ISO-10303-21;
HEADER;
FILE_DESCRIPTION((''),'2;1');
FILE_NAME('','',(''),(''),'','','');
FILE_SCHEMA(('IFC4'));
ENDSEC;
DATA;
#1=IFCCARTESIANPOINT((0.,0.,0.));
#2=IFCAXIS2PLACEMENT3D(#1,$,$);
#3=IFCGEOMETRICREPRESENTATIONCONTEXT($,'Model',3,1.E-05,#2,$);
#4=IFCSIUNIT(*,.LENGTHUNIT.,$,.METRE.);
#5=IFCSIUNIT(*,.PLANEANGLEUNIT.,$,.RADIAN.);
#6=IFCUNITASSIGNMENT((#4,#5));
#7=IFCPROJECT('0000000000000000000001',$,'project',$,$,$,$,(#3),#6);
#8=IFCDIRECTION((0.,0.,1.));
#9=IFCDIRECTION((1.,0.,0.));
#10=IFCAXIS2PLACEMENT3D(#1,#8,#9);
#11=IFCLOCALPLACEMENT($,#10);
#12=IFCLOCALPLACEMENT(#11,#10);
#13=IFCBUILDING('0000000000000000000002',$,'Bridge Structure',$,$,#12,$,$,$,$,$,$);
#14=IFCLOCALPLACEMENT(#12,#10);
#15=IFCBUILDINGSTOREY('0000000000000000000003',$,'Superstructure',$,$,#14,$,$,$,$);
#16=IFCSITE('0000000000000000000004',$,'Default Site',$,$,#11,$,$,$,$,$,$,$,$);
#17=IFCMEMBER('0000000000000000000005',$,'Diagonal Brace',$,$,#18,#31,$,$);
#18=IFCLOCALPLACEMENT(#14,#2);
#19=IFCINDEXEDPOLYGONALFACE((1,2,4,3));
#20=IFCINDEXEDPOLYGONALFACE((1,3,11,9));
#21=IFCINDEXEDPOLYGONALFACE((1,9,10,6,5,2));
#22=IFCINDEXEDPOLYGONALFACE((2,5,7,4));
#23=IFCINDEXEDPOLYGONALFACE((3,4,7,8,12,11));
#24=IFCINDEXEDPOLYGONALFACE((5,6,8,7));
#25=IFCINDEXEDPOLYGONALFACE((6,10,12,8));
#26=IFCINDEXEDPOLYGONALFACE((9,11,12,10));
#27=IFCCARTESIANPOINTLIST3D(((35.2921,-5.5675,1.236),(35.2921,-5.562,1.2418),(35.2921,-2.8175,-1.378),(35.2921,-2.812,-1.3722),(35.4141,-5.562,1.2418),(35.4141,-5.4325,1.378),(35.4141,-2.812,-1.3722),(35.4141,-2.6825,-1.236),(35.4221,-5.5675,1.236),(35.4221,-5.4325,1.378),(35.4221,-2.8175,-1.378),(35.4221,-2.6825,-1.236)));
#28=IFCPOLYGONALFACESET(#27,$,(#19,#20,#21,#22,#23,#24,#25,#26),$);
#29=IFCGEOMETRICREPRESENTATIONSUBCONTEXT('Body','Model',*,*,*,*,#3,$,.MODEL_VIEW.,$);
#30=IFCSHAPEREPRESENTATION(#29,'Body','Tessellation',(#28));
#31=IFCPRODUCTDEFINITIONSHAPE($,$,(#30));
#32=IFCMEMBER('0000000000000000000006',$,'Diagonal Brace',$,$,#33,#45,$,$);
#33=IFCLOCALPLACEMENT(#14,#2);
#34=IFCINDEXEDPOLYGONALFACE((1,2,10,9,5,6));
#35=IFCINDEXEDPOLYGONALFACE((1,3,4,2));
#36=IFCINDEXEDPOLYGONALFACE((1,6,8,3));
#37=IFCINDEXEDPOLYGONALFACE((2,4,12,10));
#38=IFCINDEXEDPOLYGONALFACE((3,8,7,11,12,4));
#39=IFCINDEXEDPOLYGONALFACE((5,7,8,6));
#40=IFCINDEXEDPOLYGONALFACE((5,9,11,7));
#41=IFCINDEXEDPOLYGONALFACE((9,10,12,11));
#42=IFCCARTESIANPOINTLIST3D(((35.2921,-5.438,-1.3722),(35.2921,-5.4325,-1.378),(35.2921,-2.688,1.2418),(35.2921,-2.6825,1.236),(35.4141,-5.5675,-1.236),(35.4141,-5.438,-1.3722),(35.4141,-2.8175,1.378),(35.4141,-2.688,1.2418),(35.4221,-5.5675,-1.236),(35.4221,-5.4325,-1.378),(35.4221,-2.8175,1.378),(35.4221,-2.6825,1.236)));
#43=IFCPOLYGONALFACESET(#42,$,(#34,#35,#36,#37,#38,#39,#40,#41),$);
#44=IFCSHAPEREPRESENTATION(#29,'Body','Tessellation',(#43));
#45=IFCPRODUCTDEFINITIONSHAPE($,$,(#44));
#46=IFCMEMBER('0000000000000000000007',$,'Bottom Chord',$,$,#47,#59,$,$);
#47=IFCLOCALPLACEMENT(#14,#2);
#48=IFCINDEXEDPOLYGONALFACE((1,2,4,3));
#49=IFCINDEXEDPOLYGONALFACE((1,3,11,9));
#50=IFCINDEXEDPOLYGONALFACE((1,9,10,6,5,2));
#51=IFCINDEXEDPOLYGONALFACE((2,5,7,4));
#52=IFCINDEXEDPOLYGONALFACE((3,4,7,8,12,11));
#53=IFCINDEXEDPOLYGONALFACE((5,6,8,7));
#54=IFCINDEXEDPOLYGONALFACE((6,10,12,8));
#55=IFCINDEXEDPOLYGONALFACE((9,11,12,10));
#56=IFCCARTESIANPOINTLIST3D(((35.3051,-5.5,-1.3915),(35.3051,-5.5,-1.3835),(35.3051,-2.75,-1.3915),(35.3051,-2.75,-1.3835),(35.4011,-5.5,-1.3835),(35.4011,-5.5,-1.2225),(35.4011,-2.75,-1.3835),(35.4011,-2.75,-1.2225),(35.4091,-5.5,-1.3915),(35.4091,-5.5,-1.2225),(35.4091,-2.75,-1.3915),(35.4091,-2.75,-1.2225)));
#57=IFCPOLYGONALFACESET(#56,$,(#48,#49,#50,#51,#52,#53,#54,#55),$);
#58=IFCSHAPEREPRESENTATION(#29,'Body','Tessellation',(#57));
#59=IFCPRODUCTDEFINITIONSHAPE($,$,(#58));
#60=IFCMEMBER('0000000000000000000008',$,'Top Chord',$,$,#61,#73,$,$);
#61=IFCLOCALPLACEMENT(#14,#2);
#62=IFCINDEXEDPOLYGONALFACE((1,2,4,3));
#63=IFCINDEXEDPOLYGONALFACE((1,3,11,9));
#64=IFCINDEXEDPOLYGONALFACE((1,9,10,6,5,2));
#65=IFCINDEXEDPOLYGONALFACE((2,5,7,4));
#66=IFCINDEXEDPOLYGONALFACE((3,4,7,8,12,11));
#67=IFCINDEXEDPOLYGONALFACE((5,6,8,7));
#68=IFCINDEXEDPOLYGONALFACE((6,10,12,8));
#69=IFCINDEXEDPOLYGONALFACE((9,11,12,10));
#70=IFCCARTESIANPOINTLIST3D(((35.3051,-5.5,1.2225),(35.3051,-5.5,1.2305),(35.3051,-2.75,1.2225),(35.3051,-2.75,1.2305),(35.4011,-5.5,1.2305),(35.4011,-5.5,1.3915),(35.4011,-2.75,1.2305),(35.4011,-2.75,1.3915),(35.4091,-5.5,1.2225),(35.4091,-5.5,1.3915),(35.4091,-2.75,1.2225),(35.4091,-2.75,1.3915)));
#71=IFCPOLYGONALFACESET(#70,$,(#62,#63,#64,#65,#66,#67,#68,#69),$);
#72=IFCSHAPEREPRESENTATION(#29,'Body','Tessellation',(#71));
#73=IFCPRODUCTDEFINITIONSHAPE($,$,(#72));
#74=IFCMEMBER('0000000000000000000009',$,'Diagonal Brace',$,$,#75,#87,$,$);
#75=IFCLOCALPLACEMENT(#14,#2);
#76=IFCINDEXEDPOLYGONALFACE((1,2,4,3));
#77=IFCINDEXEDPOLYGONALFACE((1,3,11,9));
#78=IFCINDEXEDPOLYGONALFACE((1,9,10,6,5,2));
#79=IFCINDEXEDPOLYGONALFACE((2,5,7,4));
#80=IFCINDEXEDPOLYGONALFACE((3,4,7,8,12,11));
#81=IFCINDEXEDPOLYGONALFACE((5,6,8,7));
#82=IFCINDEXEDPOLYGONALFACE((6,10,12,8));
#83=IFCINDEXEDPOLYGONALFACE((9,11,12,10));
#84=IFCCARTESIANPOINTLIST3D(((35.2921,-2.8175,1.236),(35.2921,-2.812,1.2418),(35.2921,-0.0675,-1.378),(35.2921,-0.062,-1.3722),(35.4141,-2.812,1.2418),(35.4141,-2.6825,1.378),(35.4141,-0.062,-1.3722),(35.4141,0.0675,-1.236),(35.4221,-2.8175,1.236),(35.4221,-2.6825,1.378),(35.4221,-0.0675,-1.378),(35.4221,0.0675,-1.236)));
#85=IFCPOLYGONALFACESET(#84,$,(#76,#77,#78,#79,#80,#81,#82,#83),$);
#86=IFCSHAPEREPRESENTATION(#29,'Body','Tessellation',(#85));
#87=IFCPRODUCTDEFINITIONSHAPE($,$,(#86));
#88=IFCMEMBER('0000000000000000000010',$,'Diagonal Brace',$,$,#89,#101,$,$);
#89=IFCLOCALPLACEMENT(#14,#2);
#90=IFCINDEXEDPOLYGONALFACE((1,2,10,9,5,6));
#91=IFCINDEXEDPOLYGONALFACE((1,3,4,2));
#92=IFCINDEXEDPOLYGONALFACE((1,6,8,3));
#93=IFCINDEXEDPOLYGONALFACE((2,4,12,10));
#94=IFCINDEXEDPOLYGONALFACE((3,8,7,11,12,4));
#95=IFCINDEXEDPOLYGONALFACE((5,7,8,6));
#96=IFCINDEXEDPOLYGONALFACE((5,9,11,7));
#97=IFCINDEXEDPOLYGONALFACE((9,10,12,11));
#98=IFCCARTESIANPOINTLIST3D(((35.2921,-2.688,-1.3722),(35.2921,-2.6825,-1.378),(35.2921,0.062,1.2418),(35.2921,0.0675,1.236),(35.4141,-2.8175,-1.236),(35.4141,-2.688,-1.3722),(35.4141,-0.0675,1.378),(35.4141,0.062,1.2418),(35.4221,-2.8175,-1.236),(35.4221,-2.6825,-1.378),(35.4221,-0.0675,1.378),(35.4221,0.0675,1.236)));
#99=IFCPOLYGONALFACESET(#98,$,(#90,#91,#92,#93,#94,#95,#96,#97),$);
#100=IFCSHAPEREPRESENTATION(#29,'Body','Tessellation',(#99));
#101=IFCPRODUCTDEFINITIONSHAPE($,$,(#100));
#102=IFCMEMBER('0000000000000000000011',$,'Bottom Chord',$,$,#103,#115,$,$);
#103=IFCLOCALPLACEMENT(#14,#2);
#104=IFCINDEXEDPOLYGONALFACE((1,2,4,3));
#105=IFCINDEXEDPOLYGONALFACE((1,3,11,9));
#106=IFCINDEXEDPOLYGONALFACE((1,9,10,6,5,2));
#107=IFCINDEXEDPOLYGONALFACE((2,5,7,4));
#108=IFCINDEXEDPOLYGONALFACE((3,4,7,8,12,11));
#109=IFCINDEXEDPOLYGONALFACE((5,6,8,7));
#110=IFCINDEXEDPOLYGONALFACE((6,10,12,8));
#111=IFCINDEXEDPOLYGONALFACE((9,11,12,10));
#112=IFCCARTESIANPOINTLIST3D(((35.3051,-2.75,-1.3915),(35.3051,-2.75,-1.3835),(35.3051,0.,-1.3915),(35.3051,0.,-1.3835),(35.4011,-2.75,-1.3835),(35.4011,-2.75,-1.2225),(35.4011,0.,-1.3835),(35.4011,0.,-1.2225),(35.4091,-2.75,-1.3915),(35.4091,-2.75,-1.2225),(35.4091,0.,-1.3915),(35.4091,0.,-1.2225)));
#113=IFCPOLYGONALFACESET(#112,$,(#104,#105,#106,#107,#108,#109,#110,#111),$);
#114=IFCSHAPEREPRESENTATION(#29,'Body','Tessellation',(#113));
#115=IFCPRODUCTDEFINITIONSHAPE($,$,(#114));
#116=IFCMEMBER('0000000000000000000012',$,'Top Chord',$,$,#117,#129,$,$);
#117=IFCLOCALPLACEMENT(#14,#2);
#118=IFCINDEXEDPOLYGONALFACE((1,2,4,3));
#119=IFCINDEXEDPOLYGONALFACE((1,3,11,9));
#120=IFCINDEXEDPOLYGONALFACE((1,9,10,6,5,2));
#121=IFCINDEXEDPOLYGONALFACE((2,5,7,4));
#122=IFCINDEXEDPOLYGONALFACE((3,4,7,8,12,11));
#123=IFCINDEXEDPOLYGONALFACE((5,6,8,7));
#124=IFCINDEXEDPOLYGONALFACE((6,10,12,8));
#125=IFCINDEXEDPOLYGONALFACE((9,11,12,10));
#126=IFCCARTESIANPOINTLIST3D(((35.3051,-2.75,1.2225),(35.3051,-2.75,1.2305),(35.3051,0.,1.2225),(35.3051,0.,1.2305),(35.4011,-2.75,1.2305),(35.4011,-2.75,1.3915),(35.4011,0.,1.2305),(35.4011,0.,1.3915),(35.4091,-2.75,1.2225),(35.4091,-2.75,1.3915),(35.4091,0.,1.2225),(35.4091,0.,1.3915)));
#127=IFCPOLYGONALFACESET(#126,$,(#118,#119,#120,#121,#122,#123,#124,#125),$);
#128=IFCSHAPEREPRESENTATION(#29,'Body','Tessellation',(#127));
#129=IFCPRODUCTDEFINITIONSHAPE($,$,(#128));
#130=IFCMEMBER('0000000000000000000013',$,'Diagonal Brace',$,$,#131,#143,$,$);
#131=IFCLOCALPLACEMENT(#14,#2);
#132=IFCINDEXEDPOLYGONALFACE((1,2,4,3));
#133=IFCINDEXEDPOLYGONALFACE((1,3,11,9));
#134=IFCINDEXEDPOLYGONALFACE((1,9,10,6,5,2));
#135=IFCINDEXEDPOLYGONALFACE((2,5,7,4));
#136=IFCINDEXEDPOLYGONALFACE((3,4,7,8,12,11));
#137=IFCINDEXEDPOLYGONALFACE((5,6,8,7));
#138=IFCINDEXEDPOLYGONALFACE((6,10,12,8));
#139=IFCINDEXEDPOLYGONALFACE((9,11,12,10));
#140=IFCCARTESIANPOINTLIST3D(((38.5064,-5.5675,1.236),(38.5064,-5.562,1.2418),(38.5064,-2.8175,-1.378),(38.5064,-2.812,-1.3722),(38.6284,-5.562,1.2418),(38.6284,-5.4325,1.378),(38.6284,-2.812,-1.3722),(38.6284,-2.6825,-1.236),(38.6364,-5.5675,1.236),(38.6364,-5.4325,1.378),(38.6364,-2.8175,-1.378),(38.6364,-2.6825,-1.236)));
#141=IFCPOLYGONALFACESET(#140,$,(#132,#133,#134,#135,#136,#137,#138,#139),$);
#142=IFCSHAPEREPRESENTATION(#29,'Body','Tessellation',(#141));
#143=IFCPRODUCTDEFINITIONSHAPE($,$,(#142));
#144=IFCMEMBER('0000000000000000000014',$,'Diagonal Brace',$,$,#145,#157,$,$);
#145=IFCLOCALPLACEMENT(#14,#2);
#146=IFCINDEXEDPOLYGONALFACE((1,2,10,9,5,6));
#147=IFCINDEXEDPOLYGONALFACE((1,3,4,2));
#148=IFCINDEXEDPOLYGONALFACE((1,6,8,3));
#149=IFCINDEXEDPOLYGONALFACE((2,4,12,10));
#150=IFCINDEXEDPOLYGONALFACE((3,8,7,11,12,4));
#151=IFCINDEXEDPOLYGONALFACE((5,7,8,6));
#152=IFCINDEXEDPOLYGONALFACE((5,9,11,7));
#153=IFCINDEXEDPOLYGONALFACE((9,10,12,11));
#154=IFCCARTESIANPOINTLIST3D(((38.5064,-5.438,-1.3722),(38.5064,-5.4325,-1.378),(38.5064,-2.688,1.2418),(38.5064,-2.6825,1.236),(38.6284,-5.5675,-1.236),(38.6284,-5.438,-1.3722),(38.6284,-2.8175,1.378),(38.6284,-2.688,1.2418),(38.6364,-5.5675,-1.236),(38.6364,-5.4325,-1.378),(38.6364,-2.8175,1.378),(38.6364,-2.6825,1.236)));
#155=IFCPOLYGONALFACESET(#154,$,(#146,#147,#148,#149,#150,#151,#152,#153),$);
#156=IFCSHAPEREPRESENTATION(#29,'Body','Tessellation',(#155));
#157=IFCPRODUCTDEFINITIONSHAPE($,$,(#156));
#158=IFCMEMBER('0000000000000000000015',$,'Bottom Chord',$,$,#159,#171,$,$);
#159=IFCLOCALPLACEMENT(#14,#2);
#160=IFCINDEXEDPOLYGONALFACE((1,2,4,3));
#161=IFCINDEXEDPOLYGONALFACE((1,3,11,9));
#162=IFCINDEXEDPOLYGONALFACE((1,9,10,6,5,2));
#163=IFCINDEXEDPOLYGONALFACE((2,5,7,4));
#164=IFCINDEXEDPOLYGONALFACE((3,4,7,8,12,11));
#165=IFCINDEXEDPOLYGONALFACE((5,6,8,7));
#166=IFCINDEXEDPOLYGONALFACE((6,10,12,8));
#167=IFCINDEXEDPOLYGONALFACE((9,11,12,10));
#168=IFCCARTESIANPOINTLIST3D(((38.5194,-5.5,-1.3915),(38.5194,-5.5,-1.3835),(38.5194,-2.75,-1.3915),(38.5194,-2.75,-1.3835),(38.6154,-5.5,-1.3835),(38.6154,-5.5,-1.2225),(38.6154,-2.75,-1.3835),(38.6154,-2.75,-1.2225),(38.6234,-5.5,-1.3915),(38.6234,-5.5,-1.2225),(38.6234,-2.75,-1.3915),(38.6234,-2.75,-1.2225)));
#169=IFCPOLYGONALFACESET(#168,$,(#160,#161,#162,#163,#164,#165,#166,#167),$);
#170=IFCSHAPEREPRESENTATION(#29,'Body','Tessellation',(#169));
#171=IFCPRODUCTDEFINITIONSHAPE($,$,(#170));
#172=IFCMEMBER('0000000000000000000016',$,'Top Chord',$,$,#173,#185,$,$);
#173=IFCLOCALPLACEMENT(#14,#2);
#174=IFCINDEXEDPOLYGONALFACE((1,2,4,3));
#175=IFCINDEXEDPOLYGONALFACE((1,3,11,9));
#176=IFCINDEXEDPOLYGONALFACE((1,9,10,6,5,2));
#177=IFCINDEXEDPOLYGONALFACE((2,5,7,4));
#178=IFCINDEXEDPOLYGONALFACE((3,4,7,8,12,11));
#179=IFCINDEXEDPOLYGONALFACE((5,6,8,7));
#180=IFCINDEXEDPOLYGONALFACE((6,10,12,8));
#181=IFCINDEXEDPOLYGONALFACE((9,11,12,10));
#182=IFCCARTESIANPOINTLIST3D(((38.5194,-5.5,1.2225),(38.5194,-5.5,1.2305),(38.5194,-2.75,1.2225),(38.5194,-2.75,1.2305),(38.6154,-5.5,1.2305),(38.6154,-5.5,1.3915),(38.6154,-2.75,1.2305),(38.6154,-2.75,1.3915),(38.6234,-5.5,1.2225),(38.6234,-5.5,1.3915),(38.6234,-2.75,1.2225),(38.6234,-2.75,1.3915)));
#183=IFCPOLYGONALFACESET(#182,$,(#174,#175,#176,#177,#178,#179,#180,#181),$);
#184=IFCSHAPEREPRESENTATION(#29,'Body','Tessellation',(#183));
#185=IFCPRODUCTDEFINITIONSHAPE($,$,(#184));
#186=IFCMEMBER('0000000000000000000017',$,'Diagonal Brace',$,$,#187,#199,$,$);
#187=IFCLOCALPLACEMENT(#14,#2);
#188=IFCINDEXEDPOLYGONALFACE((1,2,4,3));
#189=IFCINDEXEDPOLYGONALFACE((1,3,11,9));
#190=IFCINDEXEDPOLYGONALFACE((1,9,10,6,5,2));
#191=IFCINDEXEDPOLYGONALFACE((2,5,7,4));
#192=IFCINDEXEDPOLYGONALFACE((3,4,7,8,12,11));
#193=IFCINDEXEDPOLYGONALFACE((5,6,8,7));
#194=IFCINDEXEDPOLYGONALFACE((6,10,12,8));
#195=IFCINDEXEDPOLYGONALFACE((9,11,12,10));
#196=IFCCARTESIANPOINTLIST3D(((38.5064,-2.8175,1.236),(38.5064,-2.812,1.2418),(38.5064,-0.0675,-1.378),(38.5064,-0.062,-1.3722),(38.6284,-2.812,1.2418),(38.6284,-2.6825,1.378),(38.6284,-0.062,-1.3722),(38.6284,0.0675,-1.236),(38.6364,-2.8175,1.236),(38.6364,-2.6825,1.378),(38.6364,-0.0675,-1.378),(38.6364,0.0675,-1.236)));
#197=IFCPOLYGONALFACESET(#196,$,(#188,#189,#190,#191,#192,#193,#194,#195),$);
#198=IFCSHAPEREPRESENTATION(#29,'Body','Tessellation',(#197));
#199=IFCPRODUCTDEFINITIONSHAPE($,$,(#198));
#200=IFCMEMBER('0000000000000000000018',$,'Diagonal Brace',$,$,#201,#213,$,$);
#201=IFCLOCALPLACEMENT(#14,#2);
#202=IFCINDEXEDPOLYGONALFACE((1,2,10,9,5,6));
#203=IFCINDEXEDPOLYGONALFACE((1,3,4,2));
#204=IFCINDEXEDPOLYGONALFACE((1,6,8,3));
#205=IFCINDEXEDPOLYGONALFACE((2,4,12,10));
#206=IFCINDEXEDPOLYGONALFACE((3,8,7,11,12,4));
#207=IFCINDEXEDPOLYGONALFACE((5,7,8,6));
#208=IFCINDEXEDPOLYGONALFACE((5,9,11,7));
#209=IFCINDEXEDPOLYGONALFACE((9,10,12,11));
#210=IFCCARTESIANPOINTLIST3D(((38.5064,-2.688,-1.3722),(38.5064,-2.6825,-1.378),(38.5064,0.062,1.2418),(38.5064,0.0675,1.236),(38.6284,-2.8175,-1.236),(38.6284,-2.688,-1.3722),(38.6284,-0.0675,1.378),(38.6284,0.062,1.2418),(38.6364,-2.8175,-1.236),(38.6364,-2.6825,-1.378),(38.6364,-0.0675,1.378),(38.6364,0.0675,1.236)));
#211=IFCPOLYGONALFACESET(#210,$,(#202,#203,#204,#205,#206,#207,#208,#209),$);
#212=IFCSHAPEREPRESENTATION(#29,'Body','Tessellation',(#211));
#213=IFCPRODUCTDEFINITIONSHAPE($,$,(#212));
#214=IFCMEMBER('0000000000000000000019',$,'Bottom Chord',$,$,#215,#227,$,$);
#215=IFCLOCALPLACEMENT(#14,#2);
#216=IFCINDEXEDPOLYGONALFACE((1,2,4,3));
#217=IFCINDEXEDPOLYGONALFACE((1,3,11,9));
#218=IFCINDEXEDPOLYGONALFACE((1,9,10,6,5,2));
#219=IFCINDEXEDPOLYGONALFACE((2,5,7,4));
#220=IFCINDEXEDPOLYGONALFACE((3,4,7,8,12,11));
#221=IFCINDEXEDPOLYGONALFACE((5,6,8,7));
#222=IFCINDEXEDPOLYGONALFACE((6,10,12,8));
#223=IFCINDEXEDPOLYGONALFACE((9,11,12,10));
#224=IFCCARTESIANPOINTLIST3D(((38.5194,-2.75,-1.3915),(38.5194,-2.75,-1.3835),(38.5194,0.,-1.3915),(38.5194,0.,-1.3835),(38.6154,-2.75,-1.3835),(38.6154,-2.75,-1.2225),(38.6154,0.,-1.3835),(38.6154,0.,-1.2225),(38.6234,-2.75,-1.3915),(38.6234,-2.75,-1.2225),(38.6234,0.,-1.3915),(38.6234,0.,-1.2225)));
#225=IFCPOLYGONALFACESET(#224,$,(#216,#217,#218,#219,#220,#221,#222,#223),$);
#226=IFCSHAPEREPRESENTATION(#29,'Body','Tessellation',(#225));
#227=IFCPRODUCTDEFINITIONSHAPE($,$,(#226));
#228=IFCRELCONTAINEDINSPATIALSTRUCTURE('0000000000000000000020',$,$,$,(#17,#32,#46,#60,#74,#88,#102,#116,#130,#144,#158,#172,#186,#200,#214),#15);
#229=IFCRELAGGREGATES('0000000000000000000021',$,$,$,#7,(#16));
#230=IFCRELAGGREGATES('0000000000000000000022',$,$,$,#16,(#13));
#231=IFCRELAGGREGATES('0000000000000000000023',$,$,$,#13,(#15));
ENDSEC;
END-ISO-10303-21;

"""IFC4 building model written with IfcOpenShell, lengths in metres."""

from ifc_helpers import new_model, si_unit, frame, origin, origin_with_axes, origin_2d_with_axis, place, context, subcontext, project, spatial, l_section, extrude, element, save


model = new_model("IFC4")

# Units and contexts
model_context = context("Model", 3, precision=1e-05, world=origin())
body_context = subcontext(model_context, "Body", "Model", "MODEL_VIEW")
ifc_project = project(units=[si_unit("LENGTHUNIT", "METRE"), si_unit("PLANEANGLEUNIT", "RADIAN")], contexts=[model_context])

# Site, building, storey
site_placement = place(None, origin_with_axes())
site = spatial("IfcSite", under=ifc_project, at=site_placement, Name="Default Site")
building_placement = place(site_placement, origin_with_axes())
building = spatial("IfcBuilding", under=site, at=building_placement, Name="Bridge Structure")
storey_placement = place(building_placement, origin_with_axes())
storey = spatial("IfcBuildingStorey", under=building, at=storey_placement, Name="Superstructure")

# Members
for number, where, z_axis, x_axis, name in (
    (1, (35.3571, -5.5, 1.307), (0.0, 0.724802, -0.688957), (-1.0, 0.0, 0.0), "Diagonal Brace"),
    (2, (35.3571, -5.5, -1.307), (0.0, 0.724802, 0.688957), (-1.0, 0.0, 0.0), "Diagonal Brace"),
):
    element("IfcMember", number, at=place(storey_placement, frame(where, z_axis=z_axis, x_axis=x_axis)), inside=storey, Name=name, context=body_context, shape_type="SweptSolid", body=[
        extrude(l_section(Depth=0.196, Width=0.13, Thickness=0.008, at=origin_2d_with_axis()), origin_with_axes(), (0.0, 0.0, 1.0), 3.7941),
    ])
for number, where, z_axis, x_axis, name in (
    (3, (35.3571, -5.5, -1.307), (0.0, 1.0, 0.0), (-1.0, 0.0, 0.0), "Bottom Chord"),
    (4, (35.3571, -5.5, 1.307), (0.0, 1.0, 0.0), (-1.0, 0.0, 0.0), "Top Chord"),
):
    element("IfcMember", number, at=place(storey_placement, frame(where, z_axis=z_axis, x_axis=x_axis)), inside=storey, Name=name, context=body_context, shape_type="SweptSolid", body=[
        extrude(l_section(Depth=0.169, Width=0.104, Thickness=0.008, at=origin_2d_with_axis()), origin_with_axes(), (0.0, 0.0, 1.0), 2.75),
    ])
for number, where, z_axis, x_axis, name in (
    (5, (35.3571, -2.75, 1.307), (0.0, 0.724802, -0.688957), (-1.0, 0.0, 0.0), "Diagonal Brace"),
    (6, (35.3571, -2.75, -1.307), (0.0, 0.724802, 0.688957), (-1.0, 0.0, 0.0), "Diagonal Brace"),
):
    element("IfcMember", number, at=place(storey_placement, frame(where, z_axis=z_axis, x_axis=x_axis)), inside=storey, Name=name, context=body_context, shape_type="SweptSolid", body=[
        extrude(l_section(Depth=0.196, Width=0.13, Thickness=0.008, at=origin_2d_with_axis()), origin_with_axes(), (0.0, 0.0, 1.0), 3.7941),
    ])
for number, where, z_axis, x_axis, name in (
    (7, (35.3571, -2.75, -1.307), (0.0, 1.0, 0.0), (-1.0, 0.0, 0.0), "Bottom Chord"),
    (8, (35.3571, -2.75, 1.307), (0.0, 1.0, 0.0), (-1.0, 0.0, 0.0), "Top Chord"),
):
    element("IfcMember", number, at=place(storey_placement, frame(where, z_axis=z_axis, x_axis=x_axis)), inside=storey, Name=name, context=body_context, shape_type="SweptSolid", body=[
        extrude(l_section(Depth=0.169, Width=0.104, Thickness=0.008, at=origin_2d_with_axis()), origin_with_axes(), (0.0, 0.0, 1.0), 2.75),
    ])
for number, where, z_axis, x_axis, name in (
    (9, (38.5714, -5.5, 1.307), (0.0, 0.724802, -0.688957), (-1.0, 0.0, 0.0), "Diagonal Brace"),
    (10, (38.5714, -5.5, -1.307), (0.0, 0.724802, 0.688957), (-1.0, 0.0, 0.0), "Diagonal Brace"),
):
    element("IfcMember", number, at=place(storey_placement, frame(where, z_axis=z_axis, x_axis=x_axis)), inside=storey, Name=name, context=body_context, shape_type="SweptSolid", body=[
        extrude(l_section(Depth=0.196, Width=0.13, Thickness=0.008, at=origin_2d_with_axis()), origin_with_axes(), (0.0, 0.0, 1.0), 3.7941),
    ])
for number, where, z_axis, x_axis, name in (
    (11, (38.5714, -5.5, -1.307), (0.0, 1.0, 0.0), (-1.0, 0.0, 0.0), "Bottom Chord"),
    (12, (38.5714, -5.5, 1.307), (0.0, 1.0, 0.0), (-1.0, 0.0, 0.0), "Top Chord"),
):
    element("IfcMember", number, at=place(storey_placement, frame(where, z_axis=z_axis, x_axis=x_axis)), inside=storey, Name=name, context=body_context, shape_type="SweptSolid", body=[
        extrude(l_section(Depth=0.169, Width=0.104, Thickness=0.008, at=origin_2d_with_axis()), origin_with_axes(), (0.0, 0.0, 1.0), 2.75),
    ])
for number, where, z_axis, x_axis, name in (
    (13, (38.5714, -2.75, 1.307), (0.0, 0.724802, -0.688957), (-1.0, 0.0, 0.0), "Diagonal Brace"),
    (14, (38.5714, -2.75, -1.307), (0.0, 0.724802, 0.688957), (-1.0, 0.0, 0.0), "Diagonal Brace"),
):
    element("IfcMember", number, at=place(storey_placement, frame(where, z_axis=z_axis, x_axis=x_axis)), inside=storey, Name=name, context=body_context, shape_type="SweptSolid", body=[
        extrude(l_section(Depth=0.196, Width=0.13, Thickness=0.008, at=origin_2d_with_axis()), origin_with_axes(), (0.0, 0.0, 1.0), 3.7941),
    ])
for number, where, z_axis, x_axis, name in (
    (15, (38.5714, -2.75, -1.307), (0.0, 1.0, 0.0), (-1.0, 0.0, 0.0), "Bottom Chord"),
):
    element("IfcMember", number, at=place(storey_placement, frame(where, z_axis=z_axis, x_axis=x_axis)), inside=storey, Name=name, context=body_context, shape_type="SweptSolid", body=[
        extrude(l_section(Depth=0.169, Width=0.104, Thickness=0.008, at=origin_2d_with_axis()), origin_with_axes(), (0.0, 0.0, 1.0), 2.75),
    ])

save(model, "model.ifc")
